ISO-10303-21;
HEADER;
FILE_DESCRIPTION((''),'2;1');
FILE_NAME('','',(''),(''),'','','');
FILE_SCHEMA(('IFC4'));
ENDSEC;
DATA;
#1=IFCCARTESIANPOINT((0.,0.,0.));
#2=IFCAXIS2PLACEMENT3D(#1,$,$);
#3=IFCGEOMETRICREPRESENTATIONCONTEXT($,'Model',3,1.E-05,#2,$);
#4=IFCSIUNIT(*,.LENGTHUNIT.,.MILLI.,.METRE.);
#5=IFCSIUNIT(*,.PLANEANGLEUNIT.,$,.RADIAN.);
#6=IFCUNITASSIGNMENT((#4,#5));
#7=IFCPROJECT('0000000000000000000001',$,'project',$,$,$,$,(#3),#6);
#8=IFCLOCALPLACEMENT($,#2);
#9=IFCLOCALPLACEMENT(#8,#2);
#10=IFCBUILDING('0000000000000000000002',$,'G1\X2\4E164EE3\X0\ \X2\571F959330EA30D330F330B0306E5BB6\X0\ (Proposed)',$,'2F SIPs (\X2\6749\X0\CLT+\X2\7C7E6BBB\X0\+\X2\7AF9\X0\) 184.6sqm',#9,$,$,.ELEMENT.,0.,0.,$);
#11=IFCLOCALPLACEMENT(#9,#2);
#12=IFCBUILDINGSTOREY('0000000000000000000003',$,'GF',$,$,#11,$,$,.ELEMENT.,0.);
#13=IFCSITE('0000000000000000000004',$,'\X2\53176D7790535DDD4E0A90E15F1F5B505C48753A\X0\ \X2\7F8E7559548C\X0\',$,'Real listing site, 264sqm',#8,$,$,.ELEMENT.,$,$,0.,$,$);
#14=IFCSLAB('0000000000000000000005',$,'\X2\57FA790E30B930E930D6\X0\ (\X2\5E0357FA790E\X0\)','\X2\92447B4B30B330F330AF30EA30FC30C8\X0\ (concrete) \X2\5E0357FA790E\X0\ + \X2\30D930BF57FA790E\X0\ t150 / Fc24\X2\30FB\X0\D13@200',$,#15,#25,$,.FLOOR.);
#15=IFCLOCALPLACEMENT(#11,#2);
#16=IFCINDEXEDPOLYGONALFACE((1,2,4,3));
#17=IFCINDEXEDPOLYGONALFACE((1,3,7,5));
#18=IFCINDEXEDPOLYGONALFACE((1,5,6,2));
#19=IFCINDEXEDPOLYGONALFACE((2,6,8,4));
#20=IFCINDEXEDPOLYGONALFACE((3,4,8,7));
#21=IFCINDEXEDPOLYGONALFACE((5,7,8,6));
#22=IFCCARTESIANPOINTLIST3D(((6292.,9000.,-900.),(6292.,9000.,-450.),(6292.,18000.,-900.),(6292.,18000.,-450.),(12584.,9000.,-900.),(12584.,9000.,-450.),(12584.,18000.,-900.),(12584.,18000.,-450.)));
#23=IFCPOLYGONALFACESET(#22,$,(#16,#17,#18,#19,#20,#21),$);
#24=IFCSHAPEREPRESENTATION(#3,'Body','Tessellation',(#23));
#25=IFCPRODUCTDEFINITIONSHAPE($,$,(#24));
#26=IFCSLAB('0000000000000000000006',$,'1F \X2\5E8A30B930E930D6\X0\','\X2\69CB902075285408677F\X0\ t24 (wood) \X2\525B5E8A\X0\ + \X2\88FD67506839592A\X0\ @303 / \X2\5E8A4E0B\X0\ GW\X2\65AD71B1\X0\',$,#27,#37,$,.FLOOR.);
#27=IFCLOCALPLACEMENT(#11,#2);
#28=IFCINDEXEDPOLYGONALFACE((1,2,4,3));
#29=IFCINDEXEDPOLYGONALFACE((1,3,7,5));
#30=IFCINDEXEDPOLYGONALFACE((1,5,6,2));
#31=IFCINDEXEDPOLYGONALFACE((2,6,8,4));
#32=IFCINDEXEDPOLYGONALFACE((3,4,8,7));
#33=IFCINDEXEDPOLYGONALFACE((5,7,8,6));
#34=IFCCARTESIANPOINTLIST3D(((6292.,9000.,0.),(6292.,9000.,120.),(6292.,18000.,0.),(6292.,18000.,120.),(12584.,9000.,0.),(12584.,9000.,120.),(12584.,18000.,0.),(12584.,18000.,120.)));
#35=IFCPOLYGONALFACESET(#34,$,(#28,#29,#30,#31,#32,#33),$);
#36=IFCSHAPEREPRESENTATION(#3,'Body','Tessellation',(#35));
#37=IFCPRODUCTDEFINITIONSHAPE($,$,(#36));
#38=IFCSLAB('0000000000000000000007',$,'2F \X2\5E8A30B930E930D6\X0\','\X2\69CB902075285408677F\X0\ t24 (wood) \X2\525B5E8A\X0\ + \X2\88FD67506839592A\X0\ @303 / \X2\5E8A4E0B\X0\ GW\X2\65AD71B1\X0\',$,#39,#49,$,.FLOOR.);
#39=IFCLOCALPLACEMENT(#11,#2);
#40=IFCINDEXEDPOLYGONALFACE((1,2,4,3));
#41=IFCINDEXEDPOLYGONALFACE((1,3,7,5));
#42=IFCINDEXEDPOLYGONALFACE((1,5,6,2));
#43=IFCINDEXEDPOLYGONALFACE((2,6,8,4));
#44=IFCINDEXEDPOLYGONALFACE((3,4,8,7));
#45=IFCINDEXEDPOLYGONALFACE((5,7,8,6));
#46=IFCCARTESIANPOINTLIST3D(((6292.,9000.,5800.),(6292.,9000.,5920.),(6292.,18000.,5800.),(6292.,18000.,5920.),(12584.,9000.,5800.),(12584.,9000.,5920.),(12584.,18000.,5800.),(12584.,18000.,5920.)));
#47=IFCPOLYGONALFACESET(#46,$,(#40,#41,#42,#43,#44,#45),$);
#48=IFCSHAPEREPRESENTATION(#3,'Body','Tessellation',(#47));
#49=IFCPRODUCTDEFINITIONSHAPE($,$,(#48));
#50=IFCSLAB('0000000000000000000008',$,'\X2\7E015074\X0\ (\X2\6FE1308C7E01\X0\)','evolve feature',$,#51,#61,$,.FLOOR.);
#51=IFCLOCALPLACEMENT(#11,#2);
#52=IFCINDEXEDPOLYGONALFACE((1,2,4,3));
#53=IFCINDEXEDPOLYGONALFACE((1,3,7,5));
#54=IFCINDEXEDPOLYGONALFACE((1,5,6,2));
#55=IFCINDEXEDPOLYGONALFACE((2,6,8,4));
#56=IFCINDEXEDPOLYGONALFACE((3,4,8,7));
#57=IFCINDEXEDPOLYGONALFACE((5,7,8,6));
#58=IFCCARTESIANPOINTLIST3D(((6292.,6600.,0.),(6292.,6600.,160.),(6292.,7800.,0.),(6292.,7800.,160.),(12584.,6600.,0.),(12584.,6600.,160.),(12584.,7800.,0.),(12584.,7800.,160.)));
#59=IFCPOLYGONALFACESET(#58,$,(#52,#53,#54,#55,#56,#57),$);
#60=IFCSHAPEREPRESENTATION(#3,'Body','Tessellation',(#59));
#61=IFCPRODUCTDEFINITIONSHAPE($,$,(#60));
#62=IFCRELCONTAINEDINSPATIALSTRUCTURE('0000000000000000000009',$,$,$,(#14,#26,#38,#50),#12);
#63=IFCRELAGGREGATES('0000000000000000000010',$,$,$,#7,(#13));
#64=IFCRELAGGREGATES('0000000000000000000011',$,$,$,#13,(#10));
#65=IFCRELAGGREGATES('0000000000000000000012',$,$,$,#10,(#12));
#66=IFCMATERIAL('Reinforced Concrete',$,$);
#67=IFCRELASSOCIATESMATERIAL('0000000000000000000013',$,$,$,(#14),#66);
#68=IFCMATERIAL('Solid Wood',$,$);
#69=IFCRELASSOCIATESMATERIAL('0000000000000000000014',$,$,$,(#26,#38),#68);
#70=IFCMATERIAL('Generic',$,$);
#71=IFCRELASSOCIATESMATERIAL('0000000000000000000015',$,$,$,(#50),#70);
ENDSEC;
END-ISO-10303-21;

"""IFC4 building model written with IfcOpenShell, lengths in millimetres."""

from ifc_helpers import new_model, si_unit, frame, frame_2d, origin, place, context, project, spatial, rectangle, extrude, material, element, save


model = new_model("IFC4")

# Units and contexts
model_context = context("Model", 3, precision=1e-05, world=origin())
ifc_project = project(units=[si_unit("LENGTHUNIT", "METRE", prefix="MILLI"), si_unit("PLANEANGLEUNIT", "RADIAN")], contexts=[model_context])

# Site, building, storey
site_placement = place(None, origin())
site = spatial("IfcSite", under=ifc_project, at=site_placement, Name="北海道川上郡弟子屈町 美留和", ObjectType="Real listing site, 264sqm", CompositionType="ELEMENT", RefElevation=0.0)
building_placement = place(site_placement, origin())
building = spatial("IfcBuilding", under=site, at=building_placement, Name="G1世代 土間リビングの家 (Proposed)", ObjectType="2F SIPs (杉CLT+籾殻+竹) 184.6sqm", CompositionType="ELEMENT", ElevationOfRefHeight=0.0, ElevationOfTerrain=0.0)
storey_placement = place(building_placement, origin())
storey = spatial("IfcBuildingStorey", under=building, at=storey_placement, Name="GF", CompositionType="ELEMENT", Elevation=0.0)

# Slabs
ifc_material_1 = material(Name="Reinforced Concrete")
slab_1_placement = place(storey_placement, frame((3146.0, 4500.0, -450.0)))
element("IfcSlab", 1, at=slab_1_placement, inside=storey, material=ifc_material_1, Name="基礎スラブ (布基礎)", Description="鉄筋コンクリート (concrete) 布基礎 + ベタ基礎 t150 / Fc24・D13@200", PredefinedType="FLOOR", context=model_context, shape_type="SweptSolid", body=[
    extrude(rectangle(XDim=6292.0, YDim=9000.0, at=frame_2d((3146.0, 4500.0))), frame((3146.0, 4500.0, -450.0)), (0.0, 0.0, 1.0), 450.0),
])
ifc_material_2 = material(Name="Solid Wood")
slab_2_placement = place(storey_placement, frame((3146.0, 4500.0, 0.0)))
element("IfcSlab", 2, at=slab_2_placement, inside=storey, material=ifc_material_2, Name="1F 床スラブ", Description="構造用合板 t24 (wood) 剛床 + 製材根太 @303 / 床下 GW断熱", PredefinedType="FLOOR", context=model_context, shape_type="SweptSolid", body=[
    extrude(rectangle(XDim=6292.0, YDim=9000.0, at=frame_2d((3146.0, 4500.0))), frame((3146.0, 4500.0, 0.0)), (0.0, 0.0, 1.0), 120.0),
])
slab_3_placement = place(storey_placement, frame((3146.0, 4500.0, 2900.0)))
element("IfcSlab", 3, at=slab_3_placement, inside=storey, material=ifc_material_2, Name="2F 床スラブ", Description="構造用合板 t24 (wood) 剛床 + 製材根太 @303 / 床下 GW断熱", PredefinedType="FLOOR", context=model_context, shape_type="SweptSolid", body=[
    extrude(rectangle(XDim=6292.0, YDim=9000.0, at=frame_2d((3146.0, 4500.0))), frame((3146.0, 4500.0, 2900.0)), (0.0, 0.0, 1.0), 120.0),
])
ifc_material_3 = material(Name="Generic")
slab_4_placement = place(storey_placement, frame((3146.0, 3300.0, 0.0)))
element("IfcSlab", 4, at=slab_4_placement, inside=storey, material=ifc_material_3, Name="縁側 (濡れ縁)", Description="evolve feature", PredefinedType="FLOOR", context=model_context, shape_type="SweptSolid", body=[
    extrude(rectangle(XDim=6292.0, YDim=1200.0, at=frame_2d((3146.0, 600.0))), frame((3146.0, 3300.0, 0.0)), (0.0, 0.0, 1.0), 160.0),
])

save(model, "model.ifc")
